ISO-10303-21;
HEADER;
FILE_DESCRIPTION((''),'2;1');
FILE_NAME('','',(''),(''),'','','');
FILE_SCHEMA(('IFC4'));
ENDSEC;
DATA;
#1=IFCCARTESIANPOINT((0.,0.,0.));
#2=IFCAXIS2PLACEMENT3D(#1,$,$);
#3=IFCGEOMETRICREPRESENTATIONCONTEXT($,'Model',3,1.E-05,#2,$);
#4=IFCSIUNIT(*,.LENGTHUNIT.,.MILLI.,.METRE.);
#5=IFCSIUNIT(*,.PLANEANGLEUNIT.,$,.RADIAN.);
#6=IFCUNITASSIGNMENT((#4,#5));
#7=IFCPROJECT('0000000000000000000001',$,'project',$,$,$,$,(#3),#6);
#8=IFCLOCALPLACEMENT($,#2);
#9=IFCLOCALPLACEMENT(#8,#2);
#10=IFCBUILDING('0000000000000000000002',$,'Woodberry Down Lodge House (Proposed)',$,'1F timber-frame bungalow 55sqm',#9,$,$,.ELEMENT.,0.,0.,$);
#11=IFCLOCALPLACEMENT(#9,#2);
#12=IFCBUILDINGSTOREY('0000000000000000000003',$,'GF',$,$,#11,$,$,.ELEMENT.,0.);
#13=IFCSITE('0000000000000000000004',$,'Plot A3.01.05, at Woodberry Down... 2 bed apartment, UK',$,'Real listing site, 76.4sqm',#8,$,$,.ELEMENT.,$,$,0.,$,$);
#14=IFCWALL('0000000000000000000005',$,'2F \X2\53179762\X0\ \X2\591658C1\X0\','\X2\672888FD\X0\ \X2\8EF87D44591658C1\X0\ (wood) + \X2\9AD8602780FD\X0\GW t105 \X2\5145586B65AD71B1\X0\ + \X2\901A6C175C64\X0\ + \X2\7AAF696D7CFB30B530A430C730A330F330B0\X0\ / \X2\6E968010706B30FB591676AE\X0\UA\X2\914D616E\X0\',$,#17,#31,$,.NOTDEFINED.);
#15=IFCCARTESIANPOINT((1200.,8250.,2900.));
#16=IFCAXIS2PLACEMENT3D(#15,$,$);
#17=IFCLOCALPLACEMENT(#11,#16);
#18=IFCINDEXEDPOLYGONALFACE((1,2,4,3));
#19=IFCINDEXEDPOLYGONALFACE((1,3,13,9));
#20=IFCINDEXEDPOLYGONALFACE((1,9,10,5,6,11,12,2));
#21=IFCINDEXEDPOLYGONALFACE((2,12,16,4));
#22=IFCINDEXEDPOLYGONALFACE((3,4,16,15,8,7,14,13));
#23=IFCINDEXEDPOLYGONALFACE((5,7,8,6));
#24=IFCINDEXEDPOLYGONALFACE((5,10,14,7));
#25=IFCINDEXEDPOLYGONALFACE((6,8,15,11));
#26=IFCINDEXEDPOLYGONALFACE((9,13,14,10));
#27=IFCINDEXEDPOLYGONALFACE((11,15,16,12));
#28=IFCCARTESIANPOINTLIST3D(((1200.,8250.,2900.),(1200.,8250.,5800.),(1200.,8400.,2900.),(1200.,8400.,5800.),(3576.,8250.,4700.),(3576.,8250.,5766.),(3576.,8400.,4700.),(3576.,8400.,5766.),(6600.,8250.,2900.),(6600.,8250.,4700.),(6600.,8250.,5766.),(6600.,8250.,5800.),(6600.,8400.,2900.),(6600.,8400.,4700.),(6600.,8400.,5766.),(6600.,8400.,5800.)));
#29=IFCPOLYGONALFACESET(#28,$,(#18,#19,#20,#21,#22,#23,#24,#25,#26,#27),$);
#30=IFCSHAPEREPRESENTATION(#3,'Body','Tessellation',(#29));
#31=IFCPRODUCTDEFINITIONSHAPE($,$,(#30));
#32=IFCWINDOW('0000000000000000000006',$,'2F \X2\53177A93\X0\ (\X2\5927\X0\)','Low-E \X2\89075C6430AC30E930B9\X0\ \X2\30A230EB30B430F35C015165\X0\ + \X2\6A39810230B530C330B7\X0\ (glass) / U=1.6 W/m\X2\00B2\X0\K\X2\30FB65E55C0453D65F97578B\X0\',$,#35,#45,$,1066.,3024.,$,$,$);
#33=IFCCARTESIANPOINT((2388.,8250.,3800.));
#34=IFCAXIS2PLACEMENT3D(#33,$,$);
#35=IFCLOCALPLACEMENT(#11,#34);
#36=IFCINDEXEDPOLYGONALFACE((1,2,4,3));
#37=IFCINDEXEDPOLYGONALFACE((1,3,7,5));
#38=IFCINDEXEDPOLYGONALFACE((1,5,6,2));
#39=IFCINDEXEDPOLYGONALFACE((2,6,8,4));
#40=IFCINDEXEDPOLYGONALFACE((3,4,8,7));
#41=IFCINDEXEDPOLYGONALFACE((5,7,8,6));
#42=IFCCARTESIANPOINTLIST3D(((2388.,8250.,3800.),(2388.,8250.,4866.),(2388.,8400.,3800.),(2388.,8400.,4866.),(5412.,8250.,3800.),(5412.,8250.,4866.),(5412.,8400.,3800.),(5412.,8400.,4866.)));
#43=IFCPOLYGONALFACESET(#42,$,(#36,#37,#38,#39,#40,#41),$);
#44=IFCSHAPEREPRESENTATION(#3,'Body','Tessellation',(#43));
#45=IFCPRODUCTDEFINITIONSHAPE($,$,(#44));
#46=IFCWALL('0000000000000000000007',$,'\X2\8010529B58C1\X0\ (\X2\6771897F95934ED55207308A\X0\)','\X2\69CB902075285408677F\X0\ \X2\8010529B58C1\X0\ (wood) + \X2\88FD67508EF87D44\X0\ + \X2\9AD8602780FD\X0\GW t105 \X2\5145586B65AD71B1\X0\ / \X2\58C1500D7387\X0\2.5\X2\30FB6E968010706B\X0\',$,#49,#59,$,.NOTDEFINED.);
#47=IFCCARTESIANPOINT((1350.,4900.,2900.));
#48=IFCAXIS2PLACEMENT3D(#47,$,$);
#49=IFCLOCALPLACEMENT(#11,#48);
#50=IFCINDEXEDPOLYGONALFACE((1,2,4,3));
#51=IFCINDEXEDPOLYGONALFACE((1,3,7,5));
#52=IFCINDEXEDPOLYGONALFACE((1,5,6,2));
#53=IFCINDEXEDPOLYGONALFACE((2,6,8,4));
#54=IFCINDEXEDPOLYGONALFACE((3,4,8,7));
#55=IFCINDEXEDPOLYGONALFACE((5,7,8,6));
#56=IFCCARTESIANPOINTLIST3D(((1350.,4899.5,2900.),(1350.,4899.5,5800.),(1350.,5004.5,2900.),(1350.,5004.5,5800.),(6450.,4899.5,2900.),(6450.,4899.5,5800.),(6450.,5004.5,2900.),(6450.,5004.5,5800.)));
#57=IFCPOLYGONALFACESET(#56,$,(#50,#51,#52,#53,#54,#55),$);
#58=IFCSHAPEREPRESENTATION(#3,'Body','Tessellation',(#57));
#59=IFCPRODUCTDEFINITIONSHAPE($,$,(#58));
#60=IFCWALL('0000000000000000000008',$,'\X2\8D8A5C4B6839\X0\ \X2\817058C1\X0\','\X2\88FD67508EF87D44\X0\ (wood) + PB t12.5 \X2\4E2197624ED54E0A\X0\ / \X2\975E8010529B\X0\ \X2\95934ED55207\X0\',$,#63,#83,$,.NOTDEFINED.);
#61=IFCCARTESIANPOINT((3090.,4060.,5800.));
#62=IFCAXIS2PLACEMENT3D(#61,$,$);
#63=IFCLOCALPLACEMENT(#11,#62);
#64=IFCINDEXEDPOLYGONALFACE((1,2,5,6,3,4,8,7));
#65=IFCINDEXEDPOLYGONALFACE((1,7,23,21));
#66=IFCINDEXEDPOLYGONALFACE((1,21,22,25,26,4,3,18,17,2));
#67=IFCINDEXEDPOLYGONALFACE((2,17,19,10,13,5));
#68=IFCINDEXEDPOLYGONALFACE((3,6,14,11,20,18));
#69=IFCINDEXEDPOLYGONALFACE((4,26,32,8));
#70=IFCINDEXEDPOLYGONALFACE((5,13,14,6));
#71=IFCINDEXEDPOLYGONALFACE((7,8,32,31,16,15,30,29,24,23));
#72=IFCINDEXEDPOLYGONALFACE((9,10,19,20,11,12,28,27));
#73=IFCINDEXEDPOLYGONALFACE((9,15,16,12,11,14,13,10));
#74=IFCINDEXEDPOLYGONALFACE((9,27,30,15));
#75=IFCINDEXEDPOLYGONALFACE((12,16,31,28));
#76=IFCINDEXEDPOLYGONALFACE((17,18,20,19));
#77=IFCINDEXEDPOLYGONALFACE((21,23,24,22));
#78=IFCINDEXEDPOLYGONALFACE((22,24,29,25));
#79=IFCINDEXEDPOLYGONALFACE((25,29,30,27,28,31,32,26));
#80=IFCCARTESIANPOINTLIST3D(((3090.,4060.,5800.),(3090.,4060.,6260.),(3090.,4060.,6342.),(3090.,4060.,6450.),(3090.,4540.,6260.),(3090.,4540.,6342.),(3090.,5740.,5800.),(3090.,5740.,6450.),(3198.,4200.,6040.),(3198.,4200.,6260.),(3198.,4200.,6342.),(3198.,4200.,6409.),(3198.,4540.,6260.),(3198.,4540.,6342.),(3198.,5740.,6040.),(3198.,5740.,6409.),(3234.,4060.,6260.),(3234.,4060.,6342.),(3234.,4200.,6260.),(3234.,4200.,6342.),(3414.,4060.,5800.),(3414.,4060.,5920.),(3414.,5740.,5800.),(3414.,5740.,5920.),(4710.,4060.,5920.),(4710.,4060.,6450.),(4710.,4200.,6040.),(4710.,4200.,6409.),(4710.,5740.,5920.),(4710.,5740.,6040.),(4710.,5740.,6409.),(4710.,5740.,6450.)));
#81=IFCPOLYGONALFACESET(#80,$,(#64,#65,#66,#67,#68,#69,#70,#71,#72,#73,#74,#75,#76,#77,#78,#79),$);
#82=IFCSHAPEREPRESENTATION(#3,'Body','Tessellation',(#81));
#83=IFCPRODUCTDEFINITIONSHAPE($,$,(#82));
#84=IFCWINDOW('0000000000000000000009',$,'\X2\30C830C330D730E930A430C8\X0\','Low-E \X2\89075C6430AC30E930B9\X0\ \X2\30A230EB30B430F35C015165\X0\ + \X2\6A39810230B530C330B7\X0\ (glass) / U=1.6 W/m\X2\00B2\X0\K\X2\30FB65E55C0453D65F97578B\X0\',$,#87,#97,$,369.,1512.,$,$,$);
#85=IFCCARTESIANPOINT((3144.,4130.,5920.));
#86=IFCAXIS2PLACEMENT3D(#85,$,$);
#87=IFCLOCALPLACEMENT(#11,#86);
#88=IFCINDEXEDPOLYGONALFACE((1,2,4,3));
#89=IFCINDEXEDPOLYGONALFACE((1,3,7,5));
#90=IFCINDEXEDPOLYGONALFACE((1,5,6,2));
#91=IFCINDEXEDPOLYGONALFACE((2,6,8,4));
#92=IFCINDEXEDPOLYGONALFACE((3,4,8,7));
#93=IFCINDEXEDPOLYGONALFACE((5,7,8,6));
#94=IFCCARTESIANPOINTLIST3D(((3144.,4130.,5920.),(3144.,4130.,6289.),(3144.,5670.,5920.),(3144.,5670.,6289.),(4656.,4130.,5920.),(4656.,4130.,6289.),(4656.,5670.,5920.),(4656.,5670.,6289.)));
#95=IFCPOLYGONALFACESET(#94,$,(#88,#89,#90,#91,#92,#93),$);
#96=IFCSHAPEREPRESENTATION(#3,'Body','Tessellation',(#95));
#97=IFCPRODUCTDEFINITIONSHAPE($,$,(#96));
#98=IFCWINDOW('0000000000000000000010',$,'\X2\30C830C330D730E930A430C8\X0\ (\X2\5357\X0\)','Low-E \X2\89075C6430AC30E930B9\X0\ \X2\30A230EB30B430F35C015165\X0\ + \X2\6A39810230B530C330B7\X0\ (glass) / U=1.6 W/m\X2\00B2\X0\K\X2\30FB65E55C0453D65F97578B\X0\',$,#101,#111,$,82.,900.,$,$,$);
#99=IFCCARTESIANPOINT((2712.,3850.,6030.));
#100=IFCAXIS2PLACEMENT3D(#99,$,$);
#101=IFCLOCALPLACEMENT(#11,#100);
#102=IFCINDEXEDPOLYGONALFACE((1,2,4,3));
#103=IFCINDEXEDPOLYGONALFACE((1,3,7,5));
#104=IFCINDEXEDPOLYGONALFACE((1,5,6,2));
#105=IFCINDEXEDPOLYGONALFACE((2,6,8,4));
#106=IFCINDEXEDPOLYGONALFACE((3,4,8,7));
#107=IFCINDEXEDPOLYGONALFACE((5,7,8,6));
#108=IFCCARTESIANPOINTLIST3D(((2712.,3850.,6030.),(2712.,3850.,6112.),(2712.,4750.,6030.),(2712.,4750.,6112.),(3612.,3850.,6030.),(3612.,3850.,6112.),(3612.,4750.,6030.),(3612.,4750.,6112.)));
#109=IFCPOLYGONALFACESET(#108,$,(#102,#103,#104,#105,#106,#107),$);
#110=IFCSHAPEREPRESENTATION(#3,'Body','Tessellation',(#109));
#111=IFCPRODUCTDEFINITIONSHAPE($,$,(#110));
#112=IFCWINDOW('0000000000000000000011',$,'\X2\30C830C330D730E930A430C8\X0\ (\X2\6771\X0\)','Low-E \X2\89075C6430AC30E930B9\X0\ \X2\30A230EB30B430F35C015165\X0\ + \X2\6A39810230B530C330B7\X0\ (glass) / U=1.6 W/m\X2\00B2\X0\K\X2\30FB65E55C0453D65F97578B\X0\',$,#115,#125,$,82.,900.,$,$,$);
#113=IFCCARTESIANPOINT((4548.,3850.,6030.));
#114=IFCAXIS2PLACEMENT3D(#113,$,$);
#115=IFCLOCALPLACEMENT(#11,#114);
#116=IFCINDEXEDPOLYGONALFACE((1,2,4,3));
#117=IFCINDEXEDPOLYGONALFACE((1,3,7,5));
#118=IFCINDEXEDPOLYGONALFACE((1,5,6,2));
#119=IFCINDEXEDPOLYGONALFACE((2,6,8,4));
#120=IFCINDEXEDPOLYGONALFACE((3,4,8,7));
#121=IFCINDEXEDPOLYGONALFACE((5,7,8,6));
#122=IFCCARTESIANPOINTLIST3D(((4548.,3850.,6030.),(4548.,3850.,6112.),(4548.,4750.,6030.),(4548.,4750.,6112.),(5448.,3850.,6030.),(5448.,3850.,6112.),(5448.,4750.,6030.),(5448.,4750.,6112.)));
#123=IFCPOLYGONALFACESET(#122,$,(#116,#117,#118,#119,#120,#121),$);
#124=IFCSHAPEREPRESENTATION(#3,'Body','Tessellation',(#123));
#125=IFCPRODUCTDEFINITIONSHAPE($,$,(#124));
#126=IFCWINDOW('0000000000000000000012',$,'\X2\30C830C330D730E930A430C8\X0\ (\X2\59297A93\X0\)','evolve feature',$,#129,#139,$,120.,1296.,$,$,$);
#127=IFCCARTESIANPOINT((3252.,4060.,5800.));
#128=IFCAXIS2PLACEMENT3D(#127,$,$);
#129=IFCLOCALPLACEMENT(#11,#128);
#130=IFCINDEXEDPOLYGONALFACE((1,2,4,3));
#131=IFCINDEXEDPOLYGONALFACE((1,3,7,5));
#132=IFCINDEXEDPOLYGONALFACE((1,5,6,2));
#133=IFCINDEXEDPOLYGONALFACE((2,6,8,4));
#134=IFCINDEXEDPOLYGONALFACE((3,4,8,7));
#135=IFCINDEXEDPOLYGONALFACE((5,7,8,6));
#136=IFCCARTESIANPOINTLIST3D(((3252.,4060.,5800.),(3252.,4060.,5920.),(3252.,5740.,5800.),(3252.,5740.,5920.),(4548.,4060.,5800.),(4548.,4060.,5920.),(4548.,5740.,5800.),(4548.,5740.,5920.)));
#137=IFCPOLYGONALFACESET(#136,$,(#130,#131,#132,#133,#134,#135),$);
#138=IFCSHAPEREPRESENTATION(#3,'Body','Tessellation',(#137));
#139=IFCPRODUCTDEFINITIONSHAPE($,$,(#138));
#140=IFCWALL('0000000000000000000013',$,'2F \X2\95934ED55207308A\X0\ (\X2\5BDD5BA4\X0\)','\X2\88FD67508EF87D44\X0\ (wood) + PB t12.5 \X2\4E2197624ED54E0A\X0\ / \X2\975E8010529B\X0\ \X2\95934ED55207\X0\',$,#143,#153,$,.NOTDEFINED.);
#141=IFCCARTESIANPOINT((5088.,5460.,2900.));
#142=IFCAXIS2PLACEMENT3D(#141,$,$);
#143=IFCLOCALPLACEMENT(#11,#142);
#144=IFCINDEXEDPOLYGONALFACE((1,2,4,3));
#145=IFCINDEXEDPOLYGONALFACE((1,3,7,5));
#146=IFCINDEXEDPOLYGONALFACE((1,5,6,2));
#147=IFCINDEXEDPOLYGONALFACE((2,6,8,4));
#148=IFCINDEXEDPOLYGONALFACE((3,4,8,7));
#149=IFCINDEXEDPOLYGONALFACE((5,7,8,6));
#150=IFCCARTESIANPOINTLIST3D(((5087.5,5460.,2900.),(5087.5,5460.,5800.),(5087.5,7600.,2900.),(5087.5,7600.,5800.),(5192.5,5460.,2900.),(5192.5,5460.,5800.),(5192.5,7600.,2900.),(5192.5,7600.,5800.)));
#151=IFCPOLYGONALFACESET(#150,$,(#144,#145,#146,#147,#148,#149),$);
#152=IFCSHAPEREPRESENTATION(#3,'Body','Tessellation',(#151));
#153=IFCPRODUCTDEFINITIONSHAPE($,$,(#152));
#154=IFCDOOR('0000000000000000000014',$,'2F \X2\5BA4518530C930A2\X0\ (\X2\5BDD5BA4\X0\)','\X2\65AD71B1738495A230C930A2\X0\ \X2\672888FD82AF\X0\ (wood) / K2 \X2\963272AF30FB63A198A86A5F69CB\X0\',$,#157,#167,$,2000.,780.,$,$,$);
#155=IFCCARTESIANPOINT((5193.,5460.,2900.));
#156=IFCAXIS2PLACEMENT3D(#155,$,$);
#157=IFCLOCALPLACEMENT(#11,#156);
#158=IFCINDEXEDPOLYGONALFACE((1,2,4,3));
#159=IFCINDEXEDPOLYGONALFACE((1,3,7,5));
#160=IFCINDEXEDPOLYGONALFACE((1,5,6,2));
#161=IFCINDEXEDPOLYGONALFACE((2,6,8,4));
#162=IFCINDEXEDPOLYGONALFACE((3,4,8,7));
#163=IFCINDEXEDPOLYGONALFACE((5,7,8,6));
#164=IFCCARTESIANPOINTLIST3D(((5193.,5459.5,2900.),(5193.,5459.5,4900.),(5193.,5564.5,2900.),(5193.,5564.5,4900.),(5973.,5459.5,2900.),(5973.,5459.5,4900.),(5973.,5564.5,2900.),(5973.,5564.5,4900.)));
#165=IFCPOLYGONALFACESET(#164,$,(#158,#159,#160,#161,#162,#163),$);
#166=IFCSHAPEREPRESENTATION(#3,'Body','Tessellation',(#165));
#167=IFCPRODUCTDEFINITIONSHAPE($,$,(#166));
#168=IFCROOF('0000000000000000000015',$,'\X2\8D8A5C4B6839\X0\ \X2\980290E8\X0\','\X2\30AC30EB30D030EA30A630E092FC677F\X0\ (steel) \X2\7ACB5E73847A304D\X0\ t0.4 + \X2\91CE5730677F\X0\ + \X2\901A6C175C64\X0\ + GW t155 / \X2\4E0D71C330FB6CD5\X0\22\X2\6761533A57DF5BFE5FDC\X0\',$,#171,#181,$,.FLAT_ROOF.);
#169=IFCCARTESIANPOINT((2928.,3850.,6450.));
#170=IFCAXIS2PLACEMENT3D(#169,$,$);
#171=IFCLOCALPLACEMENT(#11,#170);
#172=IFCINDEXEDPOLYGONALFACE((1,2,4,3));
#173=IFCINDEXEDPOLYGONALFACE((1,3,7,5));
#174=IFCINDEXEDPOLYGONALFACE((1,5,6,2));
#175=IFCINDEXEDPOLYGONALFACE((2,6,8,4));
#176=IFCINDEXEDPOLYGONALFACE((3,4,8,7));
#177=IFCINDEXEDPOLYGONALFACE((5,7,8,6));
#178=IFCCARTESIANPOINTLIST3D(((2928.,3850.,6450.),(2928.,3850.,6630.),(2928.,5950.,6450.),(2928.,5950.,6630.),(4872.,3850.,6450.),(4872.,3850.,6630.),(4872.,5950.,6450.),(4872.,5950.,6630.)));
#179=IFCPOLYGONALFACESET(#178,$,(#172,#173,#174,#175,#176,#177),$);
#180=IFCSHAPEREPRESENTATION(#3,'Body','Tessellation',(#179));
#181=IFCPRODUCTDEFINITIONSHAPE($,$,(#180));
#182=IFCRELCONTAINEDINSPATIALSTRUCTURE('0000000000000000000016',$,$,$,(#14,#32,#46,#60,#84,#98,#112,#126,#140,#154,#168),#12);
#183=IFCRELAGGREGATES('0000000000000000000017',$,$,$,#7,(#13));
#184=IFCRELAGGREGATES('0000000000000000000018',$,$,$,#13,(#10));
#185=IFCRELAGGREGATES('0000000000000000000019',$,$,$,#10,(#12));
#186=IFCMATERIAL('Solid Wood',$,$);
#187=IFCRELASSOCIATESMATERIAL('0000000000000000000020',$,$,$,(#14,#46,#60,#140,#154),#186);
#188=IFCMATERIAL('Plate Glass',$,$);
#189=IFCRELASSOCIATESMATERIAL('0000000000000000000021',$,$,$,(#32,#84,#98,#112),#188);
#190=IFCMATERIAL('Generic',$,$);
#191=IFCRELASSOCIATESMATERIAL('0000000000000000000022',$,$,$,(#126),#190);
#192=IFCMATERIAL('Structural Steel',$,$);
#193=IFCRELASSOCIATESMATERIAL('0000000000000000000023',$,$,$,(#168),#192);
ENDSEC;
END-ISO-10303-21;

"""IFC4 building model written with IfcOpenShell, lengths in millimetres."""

from ifc_helpers import new_model, si_unit, frame, frame_2d, origin, place, context, project, spatial, rectangle, extrude, material, element, fill, save


model = new_model("IFC4")

# Units and contexts
model_context = context("Model", 3, precision=1e-05, world=origin())
ifc_project = project(units=[si_unit("LENGTHUNIT", "METRE", prefix="MILLI"), si_unit("PLANEANGLEUNIT", "RADIAN")], contexts=[model_context])

# Site, building, storey
site_placement = place(None, origin())
site = spatial("IfcSite", under=ifc_project, at=site_placement, Name="Plot A3.01.05, at Woodberry Down... 2 bed apartment, UK", ObjectType="Real listing site, 76.4sqm", CompositionType="ELEMENT", RefElevation=0.0)
building_placement = place(site_placement, origin())
building = spatial("IfcBuilding", under=site, at=building_placement, Name="Woodberry Down Lodge House (Proposed)", ObjectType="1F timber-frame bungalow 55sqm", CompositionType="ELEMENT", ElevationOfRefHeight=0.0, ElevationOfTerrain=0.0)
storey_placement = place(building_placement, origin())
storey = spatial("IfcBuildingStorey", under=building, at=storey_placement, Name="GF", CompositionType="ELEMENT", Elevation=0.0)

# Wall, opening, window
ifc_material_1 = material(Name="Solid Wood")
wall_1_placement = place(storey_placement, frame((1200.0, 8250.0, 2900.0)))
wall_1 = element("IfcWall", 1, at=wall_1_placement, inside=storey, material=ifc_material_1, Name="2F 北面 外壁", Description="木製 軸組外壁 (wood) + 高性能GW t105 充填断熱 + 通気層 + 窯業系サイディング / 準耐火・外皮UA配慮", PredefinedType="NOTDEFINED", context=model_context, shape_type="SweptSolid", body=[
    extrude(rectangle(XDim=5400.0, YDim=150.0, at=frame_2d((2700.0, 75.0))), frame((1200.0, 8250.0, 2900.0)), (0.0, 0.0, 1.0), 2900.0),
])
opening_1_placement = place(storey_placement, frame((2388.0, 8250.0, 3800.0)))
opening_1 = element("IfcOpeningElement", 2, at=opening_1_placement, cuts=wall_1, PredefinedType="NOTDEFINED", context=model_context, shape_type="SweptSolid", body=[
    extrude(rectangle(XDim=3024.0, YDim=150.0, at=frame_2d((1512.0, 75.0))), frame((2388.0, 8250.0, 3800.0)), (0.0, 0.0, 1.0), 1066.0),
])
ifc_material_2 = material(Name="Plate Glass")
window_1_placement = place(storey_placement, frame((2388.0, 8250.0, 3800.0)))
window_1 = element("IfcWindow", 3, at=window_1_placement, inside=storey, material=ifc_material_2, Name="2F 北窓 (大)", Description="Low-E 複層ガラス アルゴン封入 + 樹脂サッシ (glass) / U=1.6 W/m²K・日射取得型", OverallHeight=1066.0, OverallWidth=3024.0, context=model_context, shape_type="SweptSolid", body=[
    extrude(rectangle(XDim=3024.0, YDim=150.0, at=frame_2d((1512.0, 75.0))), frame((2388.0, 8250.0, 3800.0)), (0.0, 0.0, 1.0), 1066.0),
])
fill(opening_1, window_1)

# Wall
wall_2_placement = place(storey_placement, frame((1350.0, 4900.0, 2900.0)))
element("IfcWall", 4, at=wall_2_placement, inside=storey, material=ifc_material_1, Name="耐力壁 (東西間仕切り)", Description="構造用合板 耐力壁 (wood) + 製材軸組 + 高性能GW t105 充填断熱 / 壁倍率2.5・準耐火", PredefinedType="NOTDEFINED", context=model_context, shape_type="SweptSolid", body=[
    extrude(rectangle(XDim=5100.0, YDim=105.0, at=frame_2d((2550.0, 52.0))), frame((1350.0, 4900.0, 2900.0)), (0.0, 0.0, 1.0), 2900.0),
])

# Wall, openings, windows
wall_3_placement = place(storey_placement, frame((3090.0, 4060.0, 5800.0)))
wall_3 = element("IfcWall", 5, at=wall_3_placement, inside=storey, material=ifc_material_1, Name="越屋根 腰壁", Description="製材軸組 (wood) + PB t12.5 両面仕上 / 非耐力 間仕切", PredefinedType="NOTDEFINED", context=model_context, shape_type="SweptSolid", body=[
    extrude(rectangle(XDim=1620.0, YDim=1680.0, at=frame_2d((810.0, 840.0))), frame((3090.0, 4060.0, 5800.0)), (0.0, 0.0, 1.0), 650.0),
])
opening_2_placement = place(storey_placement, frame((3144.0, 4130.0, 5920.0)))
opening_2 = element("IfcOpeningElement", 6, at=opening_2_placement, cuts=wall_3, PredefinedType="NOTDEFINED", context=model_context, shape_type="SweptSolid", body=[
    extrude(rectangle(XDim=1512.0, YDim=1540.0, at=frame_2d((756.0, 770.0))), frame((3144.0, 4130.0, 5920.0)), (0.0, 0.0, 1.0), 369.0),
])
opening_3_placement = place(storey_placement, frame((2712.0, 3850.0, 6030.0)))
opening_3 = element("IfcOpeningElement", 7, at=opening_3_placement, cuts=wall_3, PredefinedType="NOTDEFINED", context=model_context, shape_type="SweptSolid", body=[
    extrude(rectangle(XDim=900.0, YDim=900.0, at=frame_2d((450.0, 450.0))), frame((2712.0, 3850.0, 6030.0)), (0.0, 0.0, 1.0), 82.0),
])
opening_4_placement = place(storey_placement, frame((4548.0, 3850.0, 6030.0)))
opening_4 = element("IfcOpeningElement", 8, at=opening_4_placement, cuts=wall_3, PredefinedType="NOTDEFINED", context=model_context, shape_type="SweptSolid", body=[
    extrude(rectangle(XDim=900.0, YDim=900.0, at=frame_2d((450.0, 450.0))), frame((4548.0, 3850.0, 6030.0)), (0.0, 0.0, 1.0), 82.0),
])
opening_5_placement = place(storey_placement, frame((3252.0, 4060.0, 5800.0)))
opening_5 = element("IfcOpeningElement", 9, at=opening_5_placement, cuts=wall_3, PredefinedType="NOTDEFINED", context=model_context, shape_type="SweptSolid", body=[
    extrude(rectangle(XDim=1296.0, YDim=1680.0, at=frame_2d((648.0, 840.0))), frame((3252.0, 4060.0, 5800.0)), (0.0, 0.0, 1.0), 120.0),
])
window_2_placement = place(storey_placement, frame((3144.0, 4130.0, 5920.0)))
window_2 = element("IfcWindow", 10, at=window_2_placement, inside=storey, material=ifc_material_2, Name="トップライト", Description="Low-E 複層ガラス アルゴン封入 + 樹脂サッシ (glass) / U=1.6 W/m²K・日射取得型", OverallHeight=369.0, OverallWidth=1512.0, context=model_context, shape_type="SweptSolid", body=[
    extrude(rectangle(XDim=1512.0, YDim=1540.0, at=frame_2d((756.0, 770.0))), frame((3144.0, 4130.0, 5920.0)), (0.0, 0.0, 1.0), 369.0),
])
fill(opening_2, window_2)
window_3_placement = place(storey_placement, frame((2712.0, 3850.0, 6030.0)))
window_3 = element("IfcWindow", 11, at=window_3_placement, inside=storey, material=ifc_material_2, Name="トップライト (南)", Description="Low-E 複層ガラス アルゴン封入 + 樹脂サッシ (glass) / U=1.6 W/m²K・日射取得型", OverallHeight=82.0, OverallWidth=900.0, context=model_context, shape_type="SweptSolid", body=[
    extrude(rectangle(XDim=900.0, YDim=900.0, at=frame_2d((450.0, 450.0))), frame((2712.0, 3850.0, 6030.0)), (0.0, 0.0, 1.0), 82.0),
])
fill(opening_3, window_3)
window_4_placement = place(storey_placement, frame((4548.0, 3850.0, 6030.0)))
window_4 = element("IfcWindow", 12, at=window_4_placement, inside=storey, material=ifc_material_2, Name="トップライト (東)", Description="Low-E 複層ガラス アルゴン封入 + 樹脂サッシ (glass) / U=1.6 W/m²K・日射取得型", OverallHeight=82.0, OverallWidth=900.0, context=model_context, shape_type="SweptSolid", body=[
    extrude(rectangle(XDim=900.0, YDim=900.0, at=frame_2d((450.0, 450.0))), frame((4548.0, 3850.0, 6030.0)), (0.0, 0.0, 1.0), 82.0),
])
fill(opening_4, window_4)
ifc_material_3 = material(Name="Generic")
window_5_placement = place(storey_placement, frame((3252.0, 4060.0, 5800.0)))
window_5 = element("IfcWindow", 13, at=window_5_placement, inside=storey, material=ifc_material_3, Name="トップライト (天窓)", Description="evolve feature", OverallHeight=120.0, OverallWidth=1296.0, context=model_context, shape_type="SweptSolid", body=[
    extrude(rectangle(XDim=1296.0, YDim=1680.0, at=frame_2d((648.0, 840.0))), frame((3252.0, 4060.0, 5800.0)), (0.0, 0.0, 1.0), 120.0),
])
fill(opening_5, window_5)

# Wall
wall_4_placement = place(storey_placement, frame((5088.0, 5460.0, 2900.0)))
element("IfcWall", 14, at=wall_4_placement, inside=storey, material=ifc_material_1, Name="2F 間仕切り (寝室)", Description="製材軸組 (wood) + PB t12.5 両面仕上 / 非耐力 間仕切", PredefinedType="NOTDEFINED", context=model_context, shape_type="SweptSolid", body=[
    extrude(rectangle(XDim=105.0, YDim=2140.0, at=frame_2d((52.0, 1070.0))), frame((5088.0, 5460.0, 2900.0)), (0.0, 0.0, 1.0), 2900.0),
])

# Door
door_placement = place(storey_placement, frame((5193.0, 5460.0, 2900.0)))
element("IfcDoor", 15, at=door_placement, inside=storey, material=ifc_material_1, Name="2F 室内ドア (寝室)", Description="断熱玄関ドア 木製芯 (wood) / K2 防犯・採風機構", OverallHeight=2000.0, OverallWidth=780.0, context=model_context, shape_type="SweptSolid", body=[
    extrude(rectangle(XDim=780.0, YDim=105.0, at=frame_2d((390.0, 52.0))), frame((5193.0, 5460.0, 2900.0)), (0.0, 0.0, 1.0), 2000.0),
])

# Roof
ifc_material_4 = material(Name="Structural Steel")
roof_placement = place(storey_placement, frame((2928.0, 3850.0, 6450.0)))
element("IfcRoof", 16, at=roof_placement, inside=storey, material=ifc_material_4, Name="越屋根 頂部", Description="ガルバリウム鋼板 (steel) 立平葺き t0.4 + 野地板 + 通気層 + GW t155 / 不燃・法22条区域対応", PredefinedType="FLAT_ROOF", context=model_context, shape_type="SweptSolid", body=[
    extrude(rectangle(XDim=1944.0, YDim=2100.0, at=frame_2d((972.0, 1050.0))), frame((2928.0, 3850.0, 6450.0)), (0.0, 0.0, 1.0), 180.0),
])

save(model, "model.ifc")
